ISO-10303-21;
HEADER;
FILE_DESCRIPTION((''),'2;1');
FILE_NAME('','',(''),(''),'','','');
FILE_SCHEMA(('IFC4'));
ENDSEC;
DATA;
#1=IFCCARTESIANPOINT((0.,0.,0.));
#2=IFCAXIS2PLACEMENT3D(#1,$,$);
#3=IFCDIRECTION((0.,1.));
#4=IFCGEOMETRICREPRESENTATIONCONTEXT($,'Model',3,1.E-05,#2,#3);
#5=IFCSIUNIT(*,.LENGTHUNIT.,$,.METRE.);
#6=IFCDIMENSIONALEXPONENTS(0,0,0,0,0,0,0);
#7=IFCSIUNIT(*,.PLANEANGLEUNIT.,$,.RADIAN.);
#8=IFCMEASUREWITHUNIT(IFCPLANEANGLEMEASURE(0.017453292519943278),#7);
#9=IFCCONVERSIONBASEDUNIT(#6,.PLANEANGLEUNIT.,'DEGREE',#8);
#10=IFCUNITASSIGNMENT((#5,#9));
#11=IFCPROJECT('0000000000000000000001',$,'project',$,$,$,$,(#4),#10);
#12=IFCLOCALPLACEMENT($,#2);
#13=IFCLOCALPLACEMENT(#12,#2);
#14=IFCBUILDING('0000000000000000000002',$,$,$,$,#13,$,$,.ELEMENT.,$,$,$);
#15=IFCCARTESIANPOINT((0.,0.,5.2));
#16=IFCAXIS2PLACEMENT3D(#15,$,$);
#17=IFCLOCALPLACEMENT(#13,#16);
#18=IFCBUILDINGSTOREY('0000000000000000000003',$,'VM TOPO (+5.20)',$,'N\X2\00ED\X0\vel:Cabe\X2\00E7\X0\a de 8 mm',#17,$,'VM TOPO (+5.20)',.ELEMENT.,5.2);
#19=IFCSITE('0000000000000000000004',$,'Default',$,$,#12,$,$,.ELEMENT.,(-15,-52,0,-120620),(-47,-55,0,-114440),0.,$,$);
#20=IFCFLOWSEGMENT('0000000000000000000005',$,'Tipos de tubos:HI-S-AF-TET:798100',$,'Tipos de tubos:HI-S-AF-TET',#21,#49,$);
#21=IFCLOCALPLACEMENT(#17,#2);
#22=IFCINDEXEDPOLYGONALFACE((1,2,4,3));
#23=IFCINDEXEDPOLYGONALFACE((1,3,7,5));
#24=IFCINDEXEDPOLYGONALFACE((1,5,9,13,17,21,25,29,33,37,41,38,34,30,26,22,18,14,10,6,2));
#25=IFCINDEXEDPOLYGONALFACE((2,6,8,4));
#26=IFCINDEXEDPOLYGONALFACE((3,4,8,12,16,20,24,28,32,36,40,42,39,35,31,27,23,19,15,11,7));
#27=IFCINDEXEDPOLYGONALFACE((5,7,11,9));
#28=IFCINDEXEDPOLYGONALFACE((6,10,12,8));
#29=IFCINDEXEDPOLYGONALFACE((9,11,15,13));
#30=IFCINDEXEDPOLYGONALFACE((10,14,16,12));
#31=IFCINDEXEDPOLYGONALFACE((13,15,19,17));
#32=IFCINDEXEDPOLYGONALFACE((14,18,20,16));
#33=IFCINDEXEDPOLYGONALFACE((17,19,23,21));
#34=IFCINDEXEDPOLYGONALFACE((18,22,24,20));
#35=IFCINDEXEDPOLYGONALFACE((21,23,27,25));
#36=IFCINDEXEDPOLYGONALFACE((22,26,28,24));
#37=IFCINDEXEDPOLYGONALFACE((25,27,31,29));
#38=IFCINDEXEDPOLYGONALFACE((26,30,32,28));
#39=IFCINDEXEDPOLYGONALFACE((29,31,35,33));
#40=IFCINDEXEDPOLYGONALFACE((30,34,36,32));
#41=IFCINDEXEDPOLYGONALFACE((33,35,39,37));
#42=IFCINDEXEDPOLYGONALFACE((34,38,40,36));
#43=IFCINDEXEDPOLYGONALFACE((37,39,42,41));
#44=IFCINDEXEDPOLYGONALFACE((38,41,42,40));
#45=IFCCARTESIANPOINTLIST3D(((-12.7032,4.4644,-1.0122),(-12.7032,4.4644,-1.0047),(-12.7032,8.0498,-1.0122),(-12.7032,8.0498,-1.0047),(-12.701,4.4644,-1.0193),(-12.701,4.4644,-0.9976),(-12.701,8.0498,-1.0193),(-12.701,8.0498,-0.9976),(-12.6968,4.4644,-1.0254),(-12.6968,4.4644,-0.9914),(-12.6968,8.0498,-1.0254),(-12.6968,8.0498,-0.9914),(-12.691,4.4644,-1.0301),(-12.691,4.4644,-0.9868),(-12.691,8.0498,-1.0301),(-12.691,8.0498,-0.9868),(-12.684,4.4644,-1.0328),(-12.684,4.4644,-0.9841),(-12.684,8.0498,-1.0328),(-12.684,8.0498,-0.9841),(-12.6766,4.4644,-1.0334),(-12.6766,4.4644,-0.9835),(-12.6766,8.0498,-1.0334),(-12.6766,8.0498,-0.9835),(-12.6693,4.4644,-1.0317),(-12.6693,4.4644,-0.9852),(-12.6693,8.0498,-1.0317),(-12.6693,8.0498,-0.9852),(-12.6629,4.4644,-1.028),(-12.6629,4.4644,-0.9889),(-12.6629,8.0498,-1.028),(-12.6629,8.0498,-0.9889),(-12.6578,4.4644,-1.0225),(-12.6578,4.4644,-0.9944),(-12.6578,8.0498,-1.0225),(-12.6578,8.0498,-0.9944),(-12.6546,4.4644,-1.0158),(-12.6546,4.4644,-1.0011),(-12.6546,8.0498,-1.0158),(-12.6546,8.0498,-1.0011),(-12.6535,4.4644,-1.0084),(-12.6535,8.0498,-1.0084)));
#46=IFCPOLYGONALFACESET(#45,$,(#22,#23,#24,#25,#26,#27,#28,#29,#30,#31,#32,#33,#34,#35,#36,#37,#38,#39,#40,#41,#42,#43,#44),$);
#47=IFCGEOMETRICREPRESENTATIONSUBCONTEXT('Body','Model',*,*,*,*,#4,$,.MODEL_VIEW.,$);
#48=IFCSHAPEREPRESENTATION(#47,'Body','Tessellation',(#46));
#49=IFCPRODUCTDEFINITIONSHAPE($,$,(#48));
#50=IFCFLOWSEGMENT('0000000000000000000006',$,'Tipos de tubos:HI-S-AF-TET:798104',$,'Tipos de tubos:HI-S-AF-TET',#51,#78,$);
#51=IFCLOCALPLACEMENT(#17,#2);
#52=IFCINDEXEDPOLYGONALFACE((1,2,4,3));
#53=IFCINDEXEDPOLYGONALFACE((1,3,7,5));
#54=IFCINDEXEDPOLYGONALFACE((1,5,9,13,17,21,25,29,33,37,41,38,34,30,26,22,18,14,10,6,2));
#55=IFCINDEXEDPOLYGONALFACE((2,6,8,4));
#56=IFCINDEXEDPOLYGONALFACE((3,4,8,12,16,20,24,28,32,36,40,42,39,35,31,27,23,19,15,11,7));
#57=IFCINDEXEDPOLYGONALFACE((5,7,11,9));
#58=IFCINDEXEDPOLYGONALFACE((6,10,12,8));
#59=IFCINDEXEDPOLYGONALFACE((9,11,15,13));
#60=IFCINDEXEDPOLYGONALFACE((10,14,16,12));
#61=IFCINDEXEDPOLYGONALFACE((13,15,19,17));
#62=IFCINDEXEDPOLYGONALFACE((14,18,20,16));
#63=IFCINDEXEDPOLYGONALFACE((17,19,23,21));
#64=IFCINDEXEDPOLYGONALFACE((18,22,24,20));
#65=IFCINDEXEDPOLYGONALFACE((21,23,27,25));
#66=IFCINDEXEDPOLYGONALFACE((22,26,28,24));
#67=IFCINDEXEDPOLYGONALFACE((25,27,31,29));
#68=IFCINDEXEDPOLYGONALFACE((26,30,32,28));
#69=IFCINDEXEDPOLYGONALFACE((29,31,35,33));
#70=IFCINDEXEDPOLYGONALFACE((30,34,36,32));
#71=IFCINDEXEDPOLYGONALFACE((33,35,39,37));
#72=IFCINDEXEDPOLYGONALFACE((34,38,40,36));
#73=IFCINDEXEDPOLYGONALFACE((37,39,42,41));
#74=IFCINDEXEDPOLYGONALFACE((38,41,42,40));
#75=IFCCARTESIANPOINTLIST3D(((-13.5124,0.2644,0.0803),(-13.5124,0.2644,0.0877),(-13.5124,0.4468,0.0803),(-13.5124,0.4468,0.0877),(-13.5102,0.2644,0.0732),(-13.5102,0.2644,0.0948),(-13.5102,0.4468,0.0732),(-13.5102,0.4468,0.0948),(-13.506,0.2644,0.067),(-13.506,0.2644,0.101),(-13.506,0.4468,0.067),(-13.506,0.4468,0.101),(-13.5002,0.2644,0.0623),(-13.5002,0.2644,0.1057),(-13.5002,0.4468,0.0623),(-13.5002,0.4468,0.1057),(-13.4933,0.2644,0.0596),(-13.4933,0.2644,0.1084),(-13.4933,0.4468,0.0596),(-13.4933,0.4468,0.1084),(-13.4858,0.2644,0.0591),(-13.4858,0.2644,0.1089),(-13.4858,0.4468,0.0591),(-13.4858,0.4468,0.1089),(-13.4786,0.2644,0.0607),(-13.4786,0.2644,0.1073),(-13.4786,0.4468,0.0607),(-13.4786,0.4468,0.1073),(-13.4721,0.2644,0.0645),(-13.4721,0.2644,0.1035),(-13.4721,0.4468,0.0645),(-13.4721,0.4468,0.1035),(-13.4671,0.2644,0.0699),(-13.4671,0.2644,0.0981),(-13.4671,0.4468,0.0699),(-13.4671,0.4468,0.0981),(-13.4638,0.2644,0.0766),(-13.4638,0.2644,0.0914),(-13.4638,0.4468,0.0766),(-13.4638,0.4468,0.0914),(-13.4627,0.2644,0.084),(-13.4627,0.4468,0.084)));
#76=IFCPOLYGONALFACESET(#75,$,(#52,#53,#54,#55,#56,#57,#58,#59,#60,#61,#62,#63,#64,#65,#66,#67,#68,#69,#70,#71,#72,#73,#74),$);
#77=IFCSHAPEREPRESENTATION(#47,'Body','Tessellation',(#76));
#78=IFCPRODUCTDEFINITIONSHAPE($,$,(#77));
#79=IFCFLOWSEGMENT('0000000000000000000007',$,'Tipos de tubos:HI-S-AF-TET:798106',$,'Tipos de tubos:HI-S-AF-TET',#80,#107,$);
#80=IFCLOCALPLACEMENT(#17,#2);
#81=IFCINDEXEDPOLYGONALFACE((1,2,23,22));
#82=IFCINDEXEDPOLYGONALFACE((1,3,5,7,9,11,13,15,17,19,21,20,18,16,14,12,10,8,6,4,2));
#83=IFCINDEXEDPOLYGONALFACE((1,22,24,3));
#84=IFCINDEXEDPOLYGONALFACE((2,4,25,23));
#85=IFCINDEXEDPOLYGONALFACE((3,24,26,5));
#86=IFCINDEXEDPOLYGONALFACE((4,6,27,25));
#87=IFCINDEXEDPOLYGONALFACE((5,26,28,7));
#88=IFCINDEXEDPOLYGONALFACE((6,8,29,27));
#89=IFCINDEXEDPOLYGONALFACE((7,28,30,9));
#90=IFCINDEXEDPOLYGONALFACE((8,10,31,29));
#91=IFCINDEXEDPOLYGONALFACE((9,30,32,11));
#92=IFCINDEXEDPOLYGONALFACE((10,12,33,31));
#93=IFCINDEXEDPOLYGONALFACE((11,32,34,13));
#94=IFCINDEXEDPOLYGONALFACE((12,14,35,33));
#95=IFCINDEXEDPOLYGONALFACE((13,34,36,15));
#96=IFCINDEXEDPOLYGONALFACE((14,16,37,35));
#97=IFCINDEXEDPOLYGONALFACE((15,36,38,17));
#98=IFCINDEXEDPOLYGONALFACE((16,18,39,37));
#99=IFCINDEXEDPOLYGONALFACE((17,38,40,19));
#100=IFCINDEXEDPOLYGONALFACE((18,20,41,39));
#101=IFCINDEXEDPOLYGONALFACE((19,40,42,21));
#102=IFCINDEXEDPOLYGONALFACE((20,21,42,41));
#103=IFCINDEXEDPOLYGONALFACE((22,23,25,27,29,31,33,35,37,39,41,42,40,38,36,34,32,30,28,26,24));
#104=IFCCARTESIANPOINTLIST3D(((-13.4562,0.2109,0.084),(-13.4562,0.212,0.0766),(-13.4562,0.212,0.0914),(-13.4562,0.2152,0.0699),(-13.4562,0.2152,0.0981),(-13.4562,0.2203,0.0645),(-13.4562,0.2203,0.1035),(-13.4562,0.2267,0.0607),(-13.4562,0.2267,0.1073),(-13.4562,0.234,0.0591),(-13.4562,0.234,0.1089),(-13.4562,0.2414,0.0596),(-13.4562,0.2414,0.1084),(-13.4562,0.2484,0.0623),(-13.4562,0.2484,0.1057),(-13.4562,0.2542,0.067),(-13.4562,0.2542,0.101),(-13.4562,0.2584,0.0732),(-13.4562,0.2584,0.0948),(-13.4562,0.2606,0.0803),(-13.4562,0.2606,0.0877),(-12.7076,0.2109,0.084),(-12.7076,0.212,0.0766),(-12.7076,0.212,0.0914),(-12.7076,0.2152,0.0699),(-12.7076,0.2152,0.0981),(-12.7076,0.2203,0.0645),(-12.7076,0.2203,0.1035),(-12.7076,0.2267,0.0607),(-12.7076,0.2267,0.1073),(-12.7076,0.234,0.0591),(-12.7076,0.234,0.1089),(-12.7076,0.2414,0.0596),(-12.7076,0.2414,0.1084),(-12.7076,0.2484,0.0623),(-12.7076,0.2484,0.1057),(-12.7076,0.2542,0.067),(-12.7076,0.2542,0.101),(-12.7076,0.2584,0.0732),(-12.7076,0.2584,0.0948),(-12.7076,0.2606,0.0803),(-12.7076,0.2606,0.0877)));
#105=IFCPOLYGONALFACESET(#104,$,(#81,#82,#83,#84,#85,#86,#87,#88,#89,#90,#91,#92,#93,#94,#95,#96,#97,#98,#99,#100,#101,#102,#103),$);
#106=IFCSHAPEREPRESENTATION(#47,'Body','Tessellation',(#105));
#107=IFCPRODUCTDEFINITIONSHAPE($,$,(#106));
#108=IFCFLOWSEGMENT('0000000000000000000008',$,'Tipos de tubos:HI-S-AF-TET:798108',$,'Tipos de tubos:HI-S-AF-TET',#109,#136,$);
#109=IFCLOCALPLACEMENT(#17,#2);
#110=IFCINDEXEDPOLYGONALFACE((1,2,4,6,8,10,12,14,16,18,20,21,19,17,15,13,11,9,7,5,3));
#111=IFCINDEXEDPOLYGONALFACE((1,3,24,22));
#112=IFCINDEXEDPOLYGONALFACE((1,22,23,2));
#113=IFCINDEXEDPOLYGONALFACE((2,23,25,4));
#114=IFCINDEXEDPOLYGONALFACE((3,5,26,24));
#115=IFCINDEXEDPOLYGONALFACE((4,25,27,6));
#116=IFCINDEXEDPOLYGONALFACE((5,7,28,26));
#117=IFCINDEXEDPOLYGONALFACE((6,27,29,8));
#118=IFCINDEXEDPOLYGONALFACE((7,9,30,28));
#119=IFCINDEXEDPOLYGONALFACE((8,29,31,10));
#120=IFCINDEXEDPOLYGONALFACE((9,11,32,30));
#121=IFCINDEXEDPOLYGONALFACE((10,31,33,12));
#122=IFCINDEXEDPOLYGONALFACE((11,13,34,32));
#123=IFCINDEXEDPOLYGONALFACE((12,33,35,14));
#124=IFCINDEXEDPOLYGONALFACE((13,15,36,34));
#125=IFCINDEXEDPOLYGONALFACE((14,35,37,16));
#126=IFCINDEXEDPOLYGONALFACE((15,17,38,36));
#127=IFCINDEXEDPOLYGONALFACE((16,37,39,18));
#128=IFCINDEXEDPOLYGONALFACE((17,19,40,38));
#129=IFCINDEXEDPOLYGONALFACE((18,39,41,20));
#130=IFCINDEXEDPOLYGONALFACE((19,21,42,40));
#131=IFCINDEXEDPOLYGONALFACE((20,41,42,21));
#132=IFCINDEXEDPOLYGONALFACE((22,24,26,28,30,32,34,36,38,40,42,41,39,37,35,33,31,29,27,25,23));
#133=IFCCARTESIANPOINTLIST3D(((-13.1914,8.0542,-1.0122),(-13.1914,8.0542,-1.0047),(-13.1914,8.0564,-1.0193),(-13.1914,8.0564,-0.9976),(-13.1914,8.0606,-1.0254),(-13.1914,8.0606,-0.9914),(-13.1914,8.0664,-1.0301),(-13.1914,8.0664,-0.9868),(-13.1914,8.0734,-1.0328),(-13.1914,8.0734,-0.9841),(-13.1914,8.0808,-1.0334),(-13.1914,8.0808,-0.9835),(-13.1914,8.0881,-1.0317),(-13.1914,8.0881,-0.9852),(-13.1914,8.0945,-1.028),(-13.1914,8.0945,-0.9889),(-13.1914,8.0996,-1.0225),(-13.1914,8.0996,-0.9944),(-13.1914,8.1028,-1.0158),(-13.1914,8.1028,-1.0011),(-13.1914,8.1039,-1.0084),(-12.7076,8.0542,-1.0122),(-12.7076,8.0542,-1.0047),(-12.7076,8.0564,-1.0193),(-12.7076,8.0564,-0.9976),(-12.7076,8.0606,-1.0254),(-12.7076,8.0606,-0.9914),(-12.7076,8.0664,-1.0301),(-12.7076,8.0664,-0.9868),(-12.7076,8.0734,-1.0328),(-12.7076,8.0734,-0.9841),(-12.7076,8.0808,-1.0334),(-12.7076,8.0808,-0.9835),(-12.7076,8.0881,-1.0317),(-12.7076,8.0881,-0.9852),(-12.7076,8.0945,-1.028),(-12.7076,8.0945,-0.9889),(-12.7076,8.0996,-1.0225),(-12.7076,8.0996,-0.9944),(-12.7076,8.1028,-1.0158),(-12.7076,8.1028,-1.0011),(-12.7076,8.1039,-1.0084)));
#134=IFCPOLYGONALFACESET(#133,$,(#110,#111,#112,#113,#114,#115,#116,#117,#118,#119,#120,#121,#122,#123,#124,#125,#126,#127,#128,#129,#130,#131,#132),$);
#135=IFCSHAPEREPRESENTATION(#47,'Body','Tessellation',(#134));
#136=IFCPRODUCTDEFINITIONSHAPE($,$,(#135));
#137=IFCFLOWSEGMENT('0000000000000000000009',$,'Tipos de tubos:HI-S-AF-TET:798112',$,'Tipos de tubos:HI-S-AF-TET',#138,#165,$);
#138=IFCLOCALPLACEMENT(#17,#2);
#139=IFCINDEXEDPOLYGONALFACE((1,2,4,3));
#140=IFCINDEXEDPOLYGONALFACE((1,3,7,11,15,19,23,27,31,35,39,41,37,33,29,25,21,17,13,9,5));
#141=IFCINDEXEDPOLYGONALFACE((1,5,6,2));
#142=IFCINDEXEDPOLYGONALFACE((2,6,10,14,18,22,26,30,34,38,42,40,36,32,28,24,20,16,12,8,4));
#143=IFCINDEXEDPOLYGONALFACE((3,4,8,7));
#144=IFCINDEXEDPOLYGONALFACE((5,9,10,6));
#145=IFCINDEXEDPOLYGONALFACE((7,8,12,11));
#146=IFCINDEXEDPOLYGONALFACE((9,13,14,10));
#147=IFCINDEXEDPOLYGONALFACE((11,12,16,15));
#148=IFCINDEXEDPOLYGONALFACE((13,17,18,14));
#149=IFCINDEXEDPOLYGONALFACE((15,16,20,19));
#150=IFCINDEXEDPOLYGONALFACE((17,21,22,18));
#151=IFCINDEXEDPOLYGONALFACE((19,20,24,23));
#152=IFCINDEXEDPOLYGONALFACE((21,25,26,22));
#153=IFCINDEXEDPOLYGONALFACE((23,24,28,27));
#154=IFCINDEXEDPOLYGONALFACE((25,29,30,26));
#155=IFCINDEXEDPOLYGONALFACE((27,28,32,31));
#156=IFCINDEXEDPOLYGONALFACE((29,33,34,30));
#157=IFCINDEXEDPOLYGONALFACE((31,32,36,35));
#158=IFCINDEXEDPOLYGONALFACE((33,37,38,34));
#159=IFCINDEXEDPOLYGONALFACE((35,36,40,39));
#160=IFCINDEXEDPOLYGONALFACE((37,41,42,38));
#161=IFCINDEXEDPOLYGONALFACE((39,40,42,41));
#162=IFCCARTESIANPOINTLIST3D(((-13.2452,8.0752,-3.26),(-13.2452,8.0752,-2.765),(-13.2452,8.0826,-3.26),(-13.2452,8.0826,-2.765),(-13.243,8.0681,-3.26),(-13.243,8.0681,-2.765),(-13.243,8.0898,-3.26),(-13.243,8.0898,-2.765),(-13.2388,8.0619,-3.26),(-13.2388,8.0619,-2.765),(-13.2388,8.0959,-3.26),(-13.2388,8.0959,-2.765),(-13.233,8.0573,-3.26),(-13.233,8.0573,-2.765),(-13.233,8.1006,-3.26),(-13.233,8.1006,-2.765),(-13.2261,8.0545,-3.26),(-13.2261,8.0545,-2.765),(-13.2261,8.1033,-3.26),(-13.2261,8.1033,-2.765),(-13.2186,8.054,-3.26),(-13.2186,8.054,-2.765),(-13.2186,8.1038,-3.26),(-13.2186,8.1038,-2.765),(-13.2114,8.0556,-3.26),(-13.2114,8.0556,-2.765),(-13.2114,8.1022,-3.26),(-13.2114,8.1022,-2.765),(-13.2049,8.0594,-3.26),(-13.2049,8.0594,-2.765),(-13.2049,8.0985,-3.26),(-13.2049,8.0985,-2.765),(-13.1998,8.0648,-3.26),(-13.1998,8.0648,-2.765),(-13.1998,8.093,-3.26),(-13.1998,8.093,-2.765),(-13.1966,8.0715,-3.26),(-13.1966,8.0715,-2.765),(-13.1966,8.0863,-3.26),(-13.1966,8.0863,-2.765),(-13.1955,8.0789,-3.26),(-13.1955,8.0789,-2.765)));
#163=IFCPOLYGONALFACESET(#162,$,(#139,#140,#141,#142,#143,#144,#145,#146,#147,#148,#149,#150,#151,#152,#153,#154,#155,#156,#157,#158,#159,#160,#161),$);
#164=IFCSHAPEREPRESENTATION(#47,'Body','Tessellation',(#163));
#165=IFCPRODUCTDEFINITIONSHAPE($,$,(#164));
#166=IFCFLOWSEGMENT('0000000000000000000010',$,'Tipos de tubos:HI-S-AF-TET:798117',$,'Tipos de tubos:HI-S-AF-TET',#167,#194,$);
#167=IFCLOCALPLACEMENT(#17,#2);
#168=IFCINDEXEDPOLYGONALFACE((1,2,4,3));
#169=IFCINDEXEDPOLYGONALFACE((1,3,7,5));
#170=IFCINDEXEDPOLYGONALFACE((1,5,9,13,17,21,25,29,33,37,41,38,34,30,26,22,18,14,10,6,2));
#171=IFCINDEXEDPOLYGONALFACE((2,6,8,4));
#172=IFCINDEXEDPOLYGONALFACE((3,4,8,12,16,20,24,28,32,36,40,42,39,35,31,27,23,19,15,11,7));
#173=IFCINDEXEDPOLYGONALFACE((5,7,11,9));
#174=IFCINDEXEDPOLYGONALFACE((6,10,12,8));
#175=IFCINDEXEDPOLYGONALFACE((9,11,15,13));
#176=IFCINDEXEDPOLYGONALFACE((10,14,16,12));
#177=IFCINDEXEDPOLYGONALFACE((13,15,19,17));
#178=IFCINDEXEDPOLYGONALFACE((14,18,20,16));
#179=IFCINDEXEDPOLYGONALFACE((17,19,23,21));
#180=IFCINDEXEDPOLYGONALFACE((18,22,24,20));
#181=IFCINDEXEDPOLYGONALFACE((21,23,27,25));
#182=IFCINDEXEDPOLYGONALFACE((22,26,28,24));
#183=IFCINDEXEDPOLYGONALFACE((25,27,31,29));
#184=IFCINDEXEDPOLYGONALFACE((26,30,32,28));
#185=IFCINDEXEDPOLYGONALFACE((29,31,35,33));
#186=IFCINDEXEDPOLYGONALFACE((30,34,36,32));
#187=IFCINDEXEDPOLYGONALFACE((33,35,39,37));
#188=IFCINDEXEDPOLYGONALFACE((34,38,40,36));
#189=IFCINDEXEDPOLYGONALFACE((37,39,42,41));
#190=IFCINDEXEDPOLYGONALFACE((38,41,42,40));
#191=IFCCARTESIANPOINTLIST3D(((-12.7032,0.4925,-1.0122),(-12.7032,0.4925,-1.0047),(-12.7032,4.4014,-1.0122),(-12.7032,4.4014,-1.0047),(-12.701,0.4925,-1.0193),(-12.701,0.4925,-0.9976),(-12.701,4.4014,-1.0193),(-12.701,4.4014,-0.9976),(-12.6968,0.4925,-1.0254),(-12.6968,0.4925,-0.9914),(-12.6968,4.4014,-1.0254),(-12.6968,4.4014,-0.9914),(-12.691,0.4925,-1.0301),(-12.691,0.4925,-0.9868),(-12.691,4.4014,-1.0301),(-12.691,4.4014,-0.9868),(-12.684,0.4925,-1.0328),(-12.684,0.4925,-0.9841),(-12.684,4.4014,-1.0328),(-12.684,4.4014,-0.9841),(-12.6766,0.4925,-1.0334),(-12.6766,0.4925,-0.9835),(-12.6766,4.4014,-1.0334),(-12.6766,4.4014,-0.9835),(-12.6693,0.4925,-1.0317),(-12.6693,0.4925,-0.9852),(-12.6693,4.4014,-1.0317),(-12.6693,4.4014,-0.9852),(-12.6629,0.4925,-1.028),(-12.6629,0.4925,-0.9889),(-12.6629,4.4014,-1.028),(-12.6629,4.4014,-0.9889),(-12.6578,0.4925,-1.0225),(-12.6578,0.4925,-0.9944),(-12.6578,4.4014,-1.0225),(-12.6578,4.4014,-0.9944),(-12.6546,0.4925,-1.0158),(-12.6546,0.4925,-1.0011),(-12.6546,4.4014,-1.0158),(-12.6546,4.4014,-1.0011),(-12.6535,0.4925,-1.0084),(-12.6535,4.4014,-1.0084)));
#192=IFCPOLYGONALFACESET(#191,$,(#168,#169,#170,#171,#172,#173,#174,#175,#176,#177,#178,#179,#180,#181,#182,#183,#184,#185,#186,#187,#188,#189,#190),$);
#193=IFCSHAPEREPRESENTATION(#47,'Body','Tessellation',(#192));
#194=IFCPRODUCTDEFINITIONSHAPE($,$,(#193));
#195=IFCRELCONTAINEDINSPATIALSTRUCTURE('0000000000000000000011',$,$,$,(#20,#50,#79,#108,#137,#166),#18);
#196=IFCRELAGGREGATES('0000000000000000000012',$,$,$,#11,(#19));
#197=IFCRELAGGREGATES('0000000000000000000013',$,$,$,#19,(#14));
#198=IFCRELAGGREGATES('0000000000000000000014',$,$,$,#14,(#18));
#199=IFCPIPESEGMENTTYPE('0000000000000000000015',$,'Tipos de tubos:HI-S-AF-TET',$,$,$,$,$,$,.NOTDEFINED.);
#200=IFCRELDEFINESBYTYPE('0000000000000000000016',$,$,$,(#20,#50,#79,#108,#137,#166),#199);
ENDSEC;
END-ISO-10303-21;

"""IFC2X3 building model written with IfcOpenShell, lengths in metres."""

from ifc_helpers import new_model, entity, si_unit, converted_unit, direction, frame, frame_2d, origin, origin_2d_with_axis, place, context, subcontext, project, spatial, circle, extrude, type_object, element, save


model = new_model("IFC2X3")

# Units and contexts
model_context = context("Model", 3, precision=1e-05, world=origin(), true_north=direction((0.0, 1.0)))
body_context = subcontext(model_context, "Body", "Model", "MODEL_VIEW")
ifc_project = project(units=[si_unit("LENGTHUNIT", "METRE"), converted_unit("PLANEANGLEUNIT", "DEGREE", entity("IfcPlaneAngleMeasure", 0.017453292519943278), si_unit("PLANEANGLEUNIT", "RADIAN"), dimensions=[0, 0, 0, 0, 0, 0, 0])], contexts=[model_context])

# Site, building, storey
site_placement = place(None, origin())
site = spatial("IfcSite", under=ifc_project, at=site_placement, Name="Default", CompositionType="ELEMENT", RefLatitude=(-15, -52, 0, -120620), RefLongitude=(-47, -55, 0, -114440), RefElevation=0.0)
building_placement = place(site_placement, origin())
building = spatial("IfcBuilding", under=site, at=building_placement, CompositionType="ELEMENT")
storey_placement = place(building_placement, frame((0.0, 0.0, 5.2)))
storey = spatial("IfcBuildingStorey", under=building, at=storey_placement, Name="VM TOPO (+5.20)", ObjectType="Nível:Cabeça de 8 mm", LongName="VM TOPO (+5.20)", CompositionType="ELEMENT", Elevation=5.2)

# Flow segments
pipe_segment_type_1 = type_object("IfcPipeSegmentType", Name="Tipos de tubos:HI-S-AF-TET", PredefinedType="NOTDEFINED")
flow_segment_1_placement = place(storey_placement, origin())
element("IfcFlowSegment", 1, at=flow_segment_1_placement, inside=storey, type_object=pipe_segment_type_1, Name="Tipos de tubos:HI-S-AF-TET:798100", ObjectType="Tipos de tubos:HI-S-AF-TET", context=body_context, shape_type="SweptSolid", body=[
    extrude(circle(Radius=0.025, at=origin_2d_with_axis()), frame((-12.6785, 4.4644, -1.0084), z_axis=(0.0, 1.0, 0.0), x_axis=(1.0, 0.0, 0.0)), (0.0, 0.0, 1.0), 3.5854),
])
flow_segment_2_placement = place(storey_placement, origin())
element("IfcFlowSegment", 2, at=flow_segment_2_placement, inside=storey, type_object=pipe_segment_type_1, Name="Tipos de tubos:HI-S-AF-TET:798104", ObjectType="Tipos de tubos:HI-S-AF-TET", context=body_context, shape_type="SweptSolid", body=[
    extrude(circle(Radius=0.025, at=frame_2d((0.0, 0.0), x_axis=(1.0, 0.0))), frame((-13.4877, 0.2644, 0.084), z_axis=(0.0, 1.0, 0.0), x_axis=(1.0, 0.0, 0.0)), (0.0, 0.0, 1.0), 0.1824),
])
flow_segment_3_placement = place(storey_placement, origin())
element("IfcFlowSegment", 3, at=flow_segment_3_placement, inside=storey, type_object=pipe_segment_type_1, Name="Tipos de tubos:HI-S-AF-TET:798106", ObjectType="Tipos de tubos:HI-S-AF-TET", context=body_context, shape_type="SweptSolid", body=[
    extrude(circle(Radius=0.025, at=frame_2d((0.0, 0.0), x_axis=(1.0, 0.0))), frame((-13.4562, 0.2359, 0.084), z_axis=(1.0, 0.0, 0.0), x_axis=(0.0, -1.0, 0.0)), (0.0, 0.0, 1.0), 0.7486),
])
flow_segment_4_placement = place(storey_placement, origin())
element("IfcFlowSegment", 4, at=flow_segment_4_placement, inside=storey, type_object=pipe_segment_type_1, Name="Tipos de tubos:HI-S-AF-TET:798108", ObjectType="Tipos de tubos:HI-S-AF-TET", context=body_context, shape_type="SweptSolid", body=[
    extrude(circle(Radius=0.025, at=frame_2d((0.0, 0.0), x_axis=(1.0, 0.0))), frame((-13.1914, 8.0789, -1.0084), z_axis=(1.0, 0.0, 0.0), x_axis=(0.0, 1.0, 0.0)), (0.0, 0.0, 1.0), 0.4838),
])
flow_segment_5_placement = place(storey_placement, origin())
element("IfcFlowSegment", 5, at=flow_segment_5_placement, inside=storey, type_object=pipe_segment_type_1, Name="Tipos de tubos:HI-S-AF-TET:798112", ObjectType="Tipos de tubos:HI-S-AF-TET", context=body_context, shape_type="SweptSolid", body=[
    extrude(circle(Radius=0.025, at=origin_2d_with_axis()), frame((-13.2205, 8.0789, -3.26)), (0.0, 0.0, 1.0), 0.495),
])
flow_segment_6_placement = place(storey_placement, origin())
element("IfcFlowSegment", 6, at=flow_segment_6_placement, inside=storey, type_object=pipe_segment_type_1, Name="Tipos de tubos:HI-S-AF-TET:798117", ObjectType="Tipos de tubos:HI-S-AF-TET", context=body_context, shape_type="SweptSolid", body=[
    extrude(circle(Radius=0.025, at=origin_2d_with_axis()), frame((-12.6785, 0.4925, -1.0084), z_axis=(0.0, 1.0, 0.0), x_axis=(1.0, 0.0, 0.0)), (0.0, 0.0, 1.0), 3.9089),
])

save(model, "model.ifc")
